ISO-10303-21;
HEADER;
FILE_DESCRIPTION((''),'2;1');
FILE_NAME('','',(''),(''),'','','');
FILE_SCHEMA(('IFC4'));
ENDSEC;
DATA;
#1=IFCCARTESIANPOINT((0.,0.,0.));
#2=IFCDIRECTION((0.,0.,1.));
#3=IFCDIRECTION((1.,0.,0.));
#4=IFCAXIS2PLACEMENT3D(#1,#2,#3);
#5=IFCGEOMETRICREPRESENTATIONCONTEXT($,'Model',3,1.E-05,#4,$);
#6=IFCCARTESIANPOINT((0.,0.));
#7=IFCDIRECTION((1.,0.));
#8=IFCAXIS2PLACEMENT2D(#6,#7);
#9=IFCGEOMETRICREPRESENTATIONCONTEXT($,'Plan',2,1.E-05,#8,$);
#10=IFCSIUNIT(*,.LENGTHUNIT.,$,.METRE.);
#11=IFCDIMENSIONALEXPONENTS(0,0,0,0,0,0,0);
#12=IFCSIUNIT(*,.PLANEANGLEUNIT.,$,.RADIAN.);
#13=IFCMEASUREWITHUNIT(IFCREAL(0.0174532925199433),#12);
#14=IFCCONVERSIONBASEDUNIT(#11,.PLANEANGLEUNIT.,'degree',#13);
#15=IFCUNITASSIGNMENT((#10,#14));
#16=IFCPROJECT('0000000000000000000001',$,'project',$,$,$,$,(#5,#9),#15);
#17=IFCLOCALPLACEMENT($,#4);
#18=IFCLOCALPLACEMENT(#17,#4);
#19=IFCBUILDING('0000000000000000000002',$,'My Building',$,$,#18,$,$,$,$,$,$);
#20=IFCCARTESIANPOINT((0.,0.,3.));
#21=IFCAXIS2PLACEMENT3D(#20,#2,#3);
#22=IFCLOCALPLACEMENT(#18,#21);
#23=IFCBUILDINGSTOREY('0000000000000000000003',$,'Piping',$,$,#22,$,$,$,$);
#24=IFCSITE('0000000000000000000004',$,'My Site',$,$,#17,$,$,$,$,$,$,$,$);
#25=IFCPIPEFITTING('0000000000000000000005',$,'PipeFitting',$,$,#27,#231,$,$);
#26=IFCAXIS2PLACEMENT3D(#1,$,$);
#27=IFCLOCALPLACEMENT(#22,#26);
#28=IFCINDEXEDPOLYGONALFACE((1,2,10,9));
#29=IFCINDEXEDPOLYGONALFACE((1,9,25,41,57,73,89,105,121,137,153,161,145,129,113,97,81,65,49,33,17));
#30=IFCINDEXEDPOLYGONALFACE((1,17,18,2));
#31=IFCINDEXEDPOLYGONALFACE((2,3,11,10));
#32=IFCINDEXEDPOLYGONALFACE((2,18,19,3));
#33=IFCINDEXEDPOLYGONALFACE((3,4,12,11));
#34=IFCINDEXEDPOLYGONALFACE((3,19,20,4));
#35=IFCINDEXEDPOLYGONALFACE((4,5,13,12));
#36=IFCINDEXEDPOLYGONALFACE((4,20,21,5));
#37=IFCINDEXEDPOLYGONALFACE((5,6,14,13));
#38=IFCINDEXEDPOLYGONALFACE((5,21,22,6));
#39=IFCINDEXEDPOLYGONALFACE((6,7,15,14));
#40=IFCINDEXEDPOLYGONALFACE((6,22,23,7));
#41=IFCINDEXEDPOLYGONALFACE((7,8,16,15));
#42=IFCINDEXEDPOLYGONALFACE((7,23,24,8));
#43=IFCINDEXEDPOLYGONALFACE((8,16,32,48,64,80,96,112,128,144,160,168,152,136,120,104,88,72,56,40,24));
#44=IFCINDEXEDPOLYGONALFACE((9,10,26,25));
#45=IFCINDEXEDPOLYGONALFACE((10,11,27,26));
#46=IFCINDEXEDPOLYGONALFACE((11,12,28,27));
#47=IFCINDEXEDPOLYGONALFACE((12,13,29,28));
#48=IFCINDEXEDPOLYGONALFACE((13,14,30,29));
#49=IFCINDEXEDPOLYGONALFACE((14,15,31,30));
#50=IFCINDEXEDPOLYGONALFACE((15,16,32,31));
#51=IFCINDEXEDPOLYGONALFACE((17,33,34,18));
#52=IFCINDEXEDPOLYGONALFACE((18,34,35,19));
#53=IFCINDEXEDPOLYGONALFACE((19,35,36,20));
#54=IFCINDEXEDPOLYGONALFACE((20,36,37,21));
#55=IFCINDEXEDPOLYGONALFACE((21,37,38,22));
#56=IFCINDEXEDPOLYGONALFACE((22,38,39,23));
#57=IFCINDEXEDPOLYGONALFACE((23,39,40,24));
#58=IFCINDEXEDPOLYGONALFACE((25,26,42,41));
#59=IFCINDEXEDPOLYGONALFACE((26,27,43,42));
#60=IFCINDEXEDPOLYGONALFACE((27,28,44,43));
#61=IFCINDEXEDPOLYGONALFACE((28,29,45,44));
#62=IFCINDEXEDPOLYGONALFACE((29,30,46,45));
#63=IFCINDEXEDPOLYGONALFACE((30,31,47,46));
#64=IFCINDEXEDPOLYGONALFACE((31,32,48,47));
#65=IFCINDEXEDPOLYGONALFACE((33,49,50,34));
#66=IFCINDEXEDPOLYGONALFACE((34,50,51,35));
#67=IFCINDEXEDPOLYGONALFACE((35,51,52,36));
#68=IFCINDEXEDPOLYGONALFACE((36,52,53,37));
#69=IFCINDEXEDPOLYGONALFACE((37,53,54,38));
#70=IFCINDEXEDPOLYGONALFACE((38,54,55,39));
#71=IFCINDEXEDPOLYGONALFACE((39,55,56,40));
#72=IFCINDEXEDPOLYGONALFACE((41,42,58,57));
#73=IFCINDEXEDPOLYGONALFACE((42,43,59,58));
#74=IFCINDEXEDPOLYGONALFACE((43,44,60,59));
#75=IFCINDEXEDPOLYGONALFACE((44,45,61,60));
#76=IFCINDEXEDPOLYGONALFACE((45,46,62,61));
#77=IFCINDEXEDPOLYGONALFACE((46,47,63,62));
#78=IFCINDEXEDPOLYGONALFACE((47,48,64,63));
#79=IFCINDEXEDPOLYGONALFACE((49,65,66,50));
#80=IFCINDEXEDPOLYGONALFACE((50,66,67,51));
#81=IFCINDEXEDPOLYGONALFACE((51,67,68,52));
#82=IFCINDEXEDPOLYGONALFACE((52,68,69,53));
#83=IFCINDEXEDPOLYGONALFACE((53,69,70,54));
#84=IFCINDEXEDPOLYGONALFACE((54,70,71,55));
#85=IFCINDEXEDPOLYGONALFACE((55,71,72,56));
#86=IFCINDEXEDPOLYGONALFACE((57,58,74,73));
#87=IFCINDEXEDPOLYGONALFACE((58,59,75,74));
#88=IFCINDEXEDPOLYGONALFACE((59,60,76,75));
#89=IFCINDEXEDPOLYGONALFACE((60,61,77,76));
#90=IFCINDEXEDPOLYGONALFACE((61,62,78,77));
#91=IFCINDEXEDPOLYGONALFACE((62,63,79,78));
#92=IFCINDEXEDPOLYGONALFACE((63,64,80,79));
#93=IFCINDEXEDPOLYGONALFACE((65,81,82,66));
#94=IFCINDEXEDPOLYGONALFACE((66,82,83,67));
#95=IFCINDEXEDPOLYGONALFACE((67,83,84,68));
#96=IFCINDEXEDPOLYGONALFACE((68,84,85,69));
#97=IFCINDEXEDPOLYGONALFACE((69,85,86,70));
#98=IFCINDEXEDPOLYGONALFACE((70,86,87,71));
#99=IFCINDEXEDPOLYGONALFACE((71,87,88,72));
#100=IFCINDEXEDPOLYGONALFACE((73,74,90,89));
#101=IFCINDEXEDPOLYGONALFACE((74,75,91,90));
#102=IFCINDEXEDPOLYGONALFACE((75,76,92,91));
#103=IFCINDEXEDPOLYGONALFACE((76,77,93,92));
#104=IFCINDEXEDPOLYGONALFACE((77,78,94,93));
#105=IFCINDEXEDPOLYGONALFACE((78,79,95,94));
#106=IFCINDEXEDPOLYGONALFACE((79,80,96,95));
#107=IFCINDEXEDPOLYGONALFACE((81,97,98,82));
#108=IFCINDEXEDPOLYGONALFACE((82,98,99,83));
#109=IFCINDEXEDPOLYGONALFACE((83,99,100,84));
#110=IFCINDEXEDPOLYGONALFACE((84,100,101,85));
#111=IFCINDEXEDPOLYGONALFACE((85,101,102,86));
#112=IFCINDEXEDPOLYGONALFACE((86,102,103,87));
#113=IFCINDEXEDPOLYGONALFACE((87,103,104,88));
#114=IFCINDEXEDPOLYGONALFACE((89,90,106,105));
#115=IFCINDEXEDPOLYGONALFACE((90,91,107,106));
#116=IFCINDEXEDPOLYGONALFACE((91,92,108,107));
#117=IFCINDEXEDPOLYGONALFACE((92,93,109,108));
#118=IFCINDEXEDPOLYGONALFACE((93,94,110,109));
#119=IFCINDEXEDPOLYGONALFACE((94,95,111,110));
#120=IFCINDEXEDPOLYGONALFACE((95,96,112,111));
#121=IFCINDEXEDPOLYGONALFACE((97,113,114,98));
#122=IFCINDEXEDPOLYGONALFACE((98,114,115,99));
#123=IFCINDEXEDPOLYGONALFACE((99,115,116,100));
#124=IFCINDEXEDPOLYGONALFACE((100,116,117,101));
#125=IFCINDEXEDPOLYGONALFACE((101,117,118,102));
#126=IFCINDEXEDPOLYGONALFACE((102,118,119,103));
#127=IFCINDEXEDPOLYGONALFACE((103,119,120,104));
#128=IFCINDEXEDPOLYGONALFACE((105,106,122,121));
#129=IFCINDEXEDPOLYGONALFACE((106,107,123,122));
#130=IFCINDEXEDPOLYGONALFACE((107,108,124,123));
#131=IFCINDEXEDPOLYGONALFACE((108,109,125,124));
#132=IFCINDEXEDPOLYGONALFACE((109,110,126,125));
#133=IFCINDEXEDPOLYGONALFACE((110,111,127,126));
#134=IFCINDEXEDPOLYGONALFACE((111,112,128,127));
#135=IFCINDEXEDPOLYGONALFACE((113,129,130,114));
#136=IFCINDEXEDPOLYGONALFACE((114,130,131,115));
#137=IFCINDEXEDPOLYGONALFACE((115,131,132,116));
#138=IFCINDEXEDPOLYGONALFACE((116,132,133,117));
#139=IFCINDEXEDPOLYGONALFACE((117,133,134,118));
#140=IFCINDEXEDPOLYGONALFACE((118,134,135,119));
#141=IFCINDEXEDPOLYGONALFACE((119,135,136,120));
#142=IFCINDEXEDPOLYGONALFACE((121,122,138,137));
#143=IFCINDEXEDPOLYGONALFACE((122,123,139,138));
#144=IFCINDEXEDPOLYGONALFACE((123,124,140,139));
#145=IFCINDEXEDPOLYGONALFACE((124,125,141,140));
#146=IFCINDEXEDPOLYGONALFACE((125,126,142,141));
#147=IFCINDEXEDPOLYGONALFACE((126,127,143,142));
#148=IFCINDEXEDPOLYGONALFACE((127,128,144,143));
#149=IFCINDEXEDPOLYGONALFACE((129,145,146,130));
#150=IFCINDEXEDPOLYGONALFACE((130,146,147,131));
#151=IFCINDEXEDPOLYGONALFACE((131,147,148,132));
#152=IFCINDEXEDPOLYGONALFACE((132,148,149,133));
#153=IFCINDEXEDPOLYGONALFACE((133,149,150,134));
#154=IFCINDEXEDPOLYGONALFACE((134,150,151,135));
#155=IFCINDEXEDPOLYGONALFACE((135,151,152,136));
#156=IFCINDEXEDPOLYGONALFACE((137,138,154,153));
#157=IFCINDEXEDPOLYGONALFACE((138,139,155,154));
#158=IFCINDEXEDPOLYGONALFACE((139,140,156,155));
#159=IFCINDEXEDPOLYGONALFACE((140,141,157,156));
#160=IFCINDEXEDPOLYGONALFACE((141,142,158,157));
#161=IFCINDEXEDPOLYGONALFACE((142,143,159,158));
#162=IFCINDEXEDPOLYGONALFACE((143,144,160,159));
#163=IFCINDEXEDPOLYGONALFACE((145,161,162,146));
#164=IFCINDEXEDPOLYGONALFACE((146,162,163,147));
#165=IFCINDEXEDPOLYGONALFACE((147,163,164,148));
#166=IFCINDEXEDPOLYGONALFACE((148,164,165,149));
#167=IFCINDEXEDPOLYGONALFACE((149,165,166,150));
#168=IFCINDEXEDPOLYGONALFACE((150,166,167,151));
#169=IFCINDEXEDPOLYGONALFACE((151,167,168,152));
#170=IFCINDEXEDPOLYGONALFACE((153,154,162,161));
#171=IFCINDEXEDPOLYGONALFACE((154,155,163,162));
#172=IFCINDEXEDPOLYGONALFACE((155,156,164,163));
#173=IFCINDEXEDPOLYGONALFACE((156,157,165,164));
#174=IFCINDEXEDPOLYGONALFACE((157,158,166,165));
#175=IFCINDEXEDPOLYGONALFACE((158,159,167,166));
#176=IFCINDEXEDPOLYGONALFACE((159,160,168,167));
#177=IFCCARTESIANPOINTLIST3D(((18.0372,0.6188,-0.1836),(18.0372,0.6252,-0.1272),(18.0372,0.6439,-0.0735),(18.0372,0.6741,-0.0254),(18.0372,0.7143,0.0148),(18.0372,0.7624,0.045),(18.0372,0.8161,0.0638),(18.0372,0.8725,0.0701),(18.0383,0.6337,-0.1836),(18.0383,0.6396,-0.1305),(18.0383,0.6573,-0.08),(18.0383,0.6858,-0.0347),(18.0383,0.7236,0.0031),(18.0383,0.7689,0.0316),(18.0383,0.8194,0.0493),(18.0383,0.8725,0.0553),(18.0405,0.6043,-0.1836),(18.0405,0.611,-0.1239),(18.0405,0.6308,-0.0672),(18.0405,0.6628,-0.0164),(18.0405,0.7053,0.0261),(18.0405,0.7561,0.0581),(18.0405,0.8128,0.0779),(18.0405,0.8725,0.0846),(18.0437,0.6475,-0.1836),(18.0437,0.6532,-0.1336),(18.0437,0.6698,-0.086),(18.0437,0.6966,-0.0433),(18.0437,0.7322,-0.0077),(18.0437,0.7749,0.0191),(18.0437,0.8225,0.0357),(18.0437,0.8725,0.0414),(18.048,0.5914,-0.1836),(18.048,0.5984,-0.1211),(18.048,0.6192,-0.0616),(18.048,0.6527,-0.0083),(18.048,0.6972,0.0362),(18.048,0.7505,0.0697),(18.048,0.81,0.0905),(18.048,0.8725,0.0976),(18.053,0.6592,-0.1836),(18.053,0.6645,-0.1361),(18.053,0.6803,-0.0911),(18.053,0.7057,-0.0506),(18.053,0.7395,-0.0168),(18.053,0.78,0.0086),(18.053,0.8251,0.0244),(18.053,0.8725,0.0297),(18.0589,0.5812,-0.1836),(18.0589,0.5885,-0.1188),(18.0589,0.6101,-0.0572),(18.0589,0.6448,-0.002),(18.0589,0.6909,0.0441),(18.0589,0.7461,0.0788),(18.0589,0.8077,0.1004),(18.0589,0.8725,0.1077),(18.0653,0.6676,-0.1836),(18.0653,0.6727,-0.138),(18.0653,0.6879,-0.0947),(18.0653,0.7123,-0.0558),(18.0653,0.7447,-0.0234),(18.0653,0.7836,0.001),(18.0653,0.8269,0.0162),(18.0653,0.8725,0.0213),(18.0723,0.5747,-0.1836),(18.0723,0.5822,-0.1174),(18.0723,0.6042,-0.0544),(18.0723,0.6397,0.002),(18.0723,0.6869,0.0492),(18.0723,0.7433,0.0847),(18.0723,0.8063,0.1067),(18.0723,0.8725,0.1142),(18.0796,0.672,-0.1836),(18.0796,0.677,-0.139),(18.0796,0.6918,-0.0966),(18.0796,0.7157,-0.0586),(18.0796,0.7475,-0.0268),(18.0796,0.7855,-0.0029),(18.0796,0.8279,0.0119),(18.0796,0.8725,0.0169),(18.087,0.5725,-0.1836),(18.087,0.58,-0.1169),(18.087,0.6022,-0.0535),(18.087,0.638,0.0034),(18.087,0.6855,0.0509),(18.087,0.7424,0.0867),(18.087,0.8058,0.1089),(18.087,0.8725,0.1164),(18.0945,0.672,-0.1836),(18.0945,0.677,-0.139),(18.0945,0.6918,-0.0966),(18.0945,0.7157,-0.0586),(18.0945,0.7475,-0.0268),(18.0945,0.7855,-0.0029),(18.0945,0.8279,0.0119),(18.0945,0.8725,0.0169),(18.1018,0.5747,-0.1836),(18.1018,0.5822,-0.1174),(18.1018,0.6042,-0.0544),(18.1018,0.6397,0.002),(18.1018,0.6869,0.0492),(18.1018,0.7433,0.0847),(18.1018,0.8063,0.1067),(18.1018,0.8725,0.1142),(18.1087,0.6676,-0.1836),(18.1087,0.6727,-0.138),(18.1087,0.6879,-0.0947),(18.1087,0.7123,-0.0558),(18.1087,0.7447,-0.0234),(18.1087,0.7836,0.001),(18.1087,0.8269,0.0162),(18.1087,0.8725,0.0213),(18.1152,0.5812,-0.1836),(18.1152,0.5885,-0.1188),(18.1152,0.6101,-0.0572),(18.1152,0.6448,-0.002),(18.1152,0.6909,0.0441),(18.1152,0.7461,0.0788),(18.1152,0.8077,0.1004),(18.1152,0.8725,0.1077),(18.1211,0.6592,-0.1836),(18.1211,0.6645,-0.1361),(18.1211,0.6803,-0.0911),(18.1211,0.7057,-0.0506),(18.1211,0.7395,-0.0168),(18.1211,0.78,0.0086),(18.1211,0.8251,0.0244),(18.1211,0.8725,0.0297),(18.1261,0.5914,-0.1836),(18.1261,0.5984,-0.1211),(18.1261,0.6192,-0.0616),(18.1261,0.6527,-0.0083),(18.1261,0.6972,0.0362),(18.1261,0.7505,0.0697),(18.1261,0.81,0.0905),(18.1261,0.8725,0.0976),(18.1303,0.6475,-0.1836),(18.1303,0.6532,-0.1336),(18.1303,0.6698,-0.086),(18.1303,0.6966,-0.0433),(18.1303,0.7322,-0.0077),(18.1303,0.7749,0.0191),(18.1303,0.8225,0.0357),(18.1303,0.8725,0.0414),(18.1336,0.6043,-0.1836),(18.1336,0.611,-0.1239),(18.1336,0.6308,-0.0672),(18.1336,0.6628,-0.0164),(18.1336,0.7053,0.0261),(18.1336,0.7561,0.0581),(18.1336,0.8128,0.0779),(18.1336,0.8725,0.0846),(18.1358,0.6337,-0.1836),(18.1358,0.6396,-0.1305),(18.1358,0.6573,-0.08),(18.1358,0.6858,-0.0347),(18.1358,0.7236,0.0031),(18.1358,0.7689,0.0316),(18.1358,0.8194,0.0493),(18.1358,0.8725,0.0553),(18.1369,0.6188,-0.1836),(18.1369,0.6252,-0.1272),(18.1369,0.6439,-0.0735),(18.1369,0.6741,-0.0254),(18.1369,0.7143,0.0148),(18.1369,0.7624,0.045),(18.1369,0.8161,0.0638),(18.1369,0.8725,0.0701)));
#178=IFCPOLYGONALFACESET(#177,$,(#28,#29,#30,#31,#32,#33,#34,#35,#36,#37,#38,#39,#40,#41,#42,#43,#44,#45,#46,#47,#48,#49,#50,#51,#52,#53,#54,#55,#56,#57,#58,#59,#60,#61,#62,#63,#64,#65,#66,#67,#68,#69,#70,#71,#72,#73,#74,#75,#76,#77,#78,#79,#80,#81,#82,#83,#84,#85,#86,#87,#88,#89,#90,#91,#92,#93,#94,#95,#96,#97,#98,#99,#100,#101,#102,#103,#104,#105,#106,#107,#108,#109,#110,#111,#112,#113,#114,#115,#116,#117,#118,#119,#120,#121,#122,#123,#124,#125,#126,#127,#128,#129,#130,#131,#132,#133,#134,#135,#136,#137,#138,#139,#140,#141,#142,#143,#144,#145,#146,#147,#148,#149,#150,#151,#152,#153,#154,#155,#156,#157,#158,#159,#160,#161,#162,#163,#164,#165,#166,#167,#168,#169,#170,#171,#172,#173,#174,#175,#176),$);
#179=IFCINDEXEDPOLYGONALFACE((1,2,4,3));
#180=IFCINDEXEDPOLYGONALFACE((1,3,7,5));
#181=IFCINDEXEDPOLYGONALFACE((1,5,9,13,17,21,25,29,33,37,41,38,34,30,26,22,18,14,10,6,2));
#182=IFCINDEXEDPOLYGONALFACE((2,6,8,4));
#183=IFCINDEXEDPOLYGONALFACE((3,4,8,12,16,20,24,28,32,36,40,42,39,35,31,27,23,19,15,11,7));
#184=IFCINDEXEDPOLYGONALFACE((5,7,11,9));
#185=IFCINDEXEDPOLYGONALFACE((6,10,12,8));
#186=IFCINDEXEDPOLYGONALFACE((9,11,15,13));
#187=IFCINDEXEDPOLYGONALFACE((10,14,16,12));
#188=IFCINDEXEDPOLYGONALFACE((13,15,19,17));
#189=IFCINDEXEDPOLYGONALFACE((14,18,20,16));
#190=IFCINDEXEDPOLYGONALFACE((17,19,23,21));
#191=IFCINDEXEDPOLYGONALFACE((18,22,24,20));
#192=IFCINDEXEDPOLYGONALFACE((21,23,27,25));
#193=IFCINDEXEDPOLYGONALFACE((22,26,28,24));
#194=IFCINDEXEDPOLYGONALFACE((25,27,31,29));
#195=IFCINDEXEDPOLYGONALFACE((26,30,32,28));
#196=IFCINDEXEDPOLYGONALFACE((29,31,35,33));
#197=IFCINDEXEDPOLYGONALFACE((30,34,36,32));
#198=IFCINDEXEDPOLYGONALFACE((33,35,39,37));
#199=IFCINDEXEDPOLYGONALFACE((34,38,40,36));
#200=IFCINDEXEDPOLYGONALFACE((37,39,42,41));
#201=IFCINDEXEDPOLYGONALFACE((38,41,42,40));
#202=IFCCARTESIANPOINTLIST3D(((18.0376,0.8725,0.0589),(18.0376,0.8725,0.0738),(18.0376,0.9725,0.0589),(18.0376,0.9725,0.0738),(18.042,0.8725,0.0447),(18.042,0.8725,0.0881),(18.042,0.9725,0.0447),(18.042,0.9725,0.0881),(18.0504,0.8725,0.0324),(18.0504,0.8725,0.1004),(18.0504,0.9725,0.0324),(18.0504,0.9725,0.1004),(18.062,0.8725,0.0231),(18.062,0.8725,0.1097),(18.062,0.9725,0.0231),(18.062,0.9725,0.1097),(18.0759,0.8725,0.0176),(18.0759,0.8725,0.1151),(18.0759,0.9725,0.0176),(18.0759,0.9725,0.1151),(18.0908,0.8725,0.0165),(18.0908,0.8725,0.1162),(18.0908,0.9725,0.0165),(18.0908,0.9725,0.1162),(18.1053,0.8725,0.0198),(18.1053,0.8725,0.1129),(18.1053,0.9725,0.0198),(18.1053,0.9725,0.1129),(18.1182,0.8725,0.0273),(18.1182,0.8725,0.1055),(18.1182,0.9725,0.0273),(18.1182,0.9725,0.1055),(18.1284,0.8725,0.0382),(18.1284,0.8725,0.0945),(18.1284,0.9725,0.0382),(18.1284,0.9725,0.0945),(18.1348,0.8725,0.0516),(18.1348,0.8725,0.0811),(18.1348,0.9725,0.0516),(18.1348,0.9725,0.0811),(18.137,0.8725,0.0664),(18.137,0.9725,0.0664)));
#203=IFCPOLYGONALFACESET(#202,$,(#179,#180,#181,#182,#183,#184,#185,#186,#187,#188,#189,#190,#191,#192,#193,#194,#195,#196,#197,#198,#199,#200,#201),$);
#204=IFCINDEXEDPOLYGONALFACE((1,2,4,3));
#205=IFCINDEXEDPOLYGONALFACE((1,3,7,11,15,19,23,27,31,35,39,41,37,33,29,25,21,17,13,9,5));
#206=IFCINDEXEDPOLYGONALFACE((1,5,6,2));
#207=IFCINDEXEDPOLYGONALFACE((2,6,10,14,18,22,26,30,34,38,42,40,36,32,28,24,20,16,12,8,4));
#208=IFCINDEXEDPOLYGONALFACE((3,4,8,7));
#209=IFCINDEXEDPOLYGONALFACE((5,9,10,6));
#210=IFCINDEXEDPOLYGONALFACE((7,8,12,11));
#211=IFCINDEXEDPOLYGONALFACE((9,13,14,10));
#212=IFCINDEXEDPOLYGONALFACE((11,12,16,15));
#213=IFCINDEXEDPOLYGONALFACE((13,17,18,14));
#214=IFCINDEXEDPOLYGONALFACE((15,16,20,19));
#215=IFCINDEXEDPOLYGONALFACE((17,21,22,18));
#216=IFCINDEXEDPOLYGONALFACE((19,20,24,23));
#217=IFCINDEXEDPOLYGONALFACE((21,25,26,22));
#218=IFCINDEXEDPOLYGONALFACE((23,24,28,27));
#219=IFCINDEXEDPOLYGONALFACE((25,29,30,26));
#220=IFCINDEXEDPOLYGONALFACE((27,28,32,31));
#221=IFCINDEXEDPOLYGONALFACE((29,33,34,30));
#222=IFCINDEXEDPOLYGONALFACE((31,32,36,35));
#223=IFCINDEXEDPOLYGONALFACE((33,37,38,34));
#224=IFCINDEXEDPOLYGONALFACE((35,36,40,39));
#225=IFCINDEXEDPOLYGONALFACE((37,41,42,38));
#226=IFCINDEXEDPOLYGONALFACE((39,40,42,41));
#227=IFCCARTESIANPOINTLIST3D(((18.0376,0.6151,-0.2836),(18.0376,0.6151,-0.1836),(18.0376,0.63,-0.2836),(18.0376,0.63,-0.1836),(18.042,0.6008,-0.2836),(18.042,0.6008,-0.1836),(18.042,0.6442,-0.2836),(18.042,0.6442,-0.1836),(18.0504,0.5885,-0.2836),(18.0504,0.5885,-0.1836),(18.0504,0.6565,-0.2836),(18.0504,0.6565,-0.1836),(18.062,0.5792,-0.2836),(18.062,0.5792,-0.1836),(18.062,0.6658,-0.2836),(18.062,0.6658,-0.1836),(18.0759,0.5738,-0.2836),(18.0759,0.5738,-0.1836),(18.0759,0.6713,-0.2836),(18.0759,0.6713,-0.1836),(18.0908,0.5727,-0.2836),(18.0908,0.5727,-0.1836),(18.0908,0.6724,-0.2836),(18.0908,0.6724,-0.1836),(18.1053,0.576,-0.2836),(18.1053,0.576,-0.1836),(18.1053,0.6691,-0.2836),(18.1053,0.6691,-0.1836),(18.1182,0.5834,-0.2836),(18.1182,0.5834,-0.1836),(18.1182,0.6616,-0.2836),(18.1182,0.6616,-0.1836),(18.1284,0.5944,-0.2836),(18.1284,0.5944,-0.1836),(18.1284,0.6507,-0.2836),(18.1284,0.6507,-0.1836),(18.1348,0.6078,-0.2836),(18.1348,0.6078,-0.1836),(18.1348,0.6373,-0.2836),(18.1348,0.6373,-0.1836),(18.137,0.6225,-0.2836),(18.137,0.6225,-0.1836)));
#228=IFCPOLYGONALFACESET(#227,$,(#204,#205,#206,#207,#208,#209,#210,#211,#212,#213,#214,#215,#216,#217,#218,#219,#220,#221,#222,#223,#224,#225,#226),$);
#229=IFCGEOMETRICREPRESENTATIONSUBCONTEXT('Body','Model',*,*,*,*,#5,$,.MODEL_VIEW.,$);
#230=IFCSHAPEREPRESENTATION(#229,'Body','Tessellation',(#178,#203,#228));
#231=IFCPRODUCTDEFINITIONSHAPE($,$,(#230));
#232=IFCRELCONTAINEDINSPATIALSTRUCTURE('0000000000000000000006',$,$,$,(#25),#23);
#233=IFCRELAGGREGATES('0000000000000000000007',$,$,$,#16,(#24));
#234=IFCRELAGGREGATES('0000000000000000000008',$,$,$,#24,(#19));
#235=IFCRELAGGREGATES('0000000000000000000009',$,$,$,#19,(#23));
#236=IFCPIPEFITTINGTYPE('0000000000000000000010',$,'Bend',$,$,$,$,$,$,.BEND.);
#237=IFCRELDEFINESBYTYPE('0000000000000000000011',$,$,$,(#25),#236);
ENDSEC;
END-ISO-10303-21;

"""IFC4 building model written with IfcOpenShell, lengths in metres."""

from ifc_helpers import new_model, entity, si_unit, converted_unit, frame, origin_with_axes, origin_2d_with_axis, place, context, subcontext, project, spatial, circle, extrude, source, transform, mapped, type_object, type_shapes, element, save


model = new_model("IFC4")

# Units and contexts
model_context = context("Model", 3, precision=1e-05, world=origin_with_axes())
plan_context = context("Plan", 2, precision=1e-05, world=origin_2d_with_axis())
body_context = subcontext(model_context, "Body", "Model", "MODEL_VIEW")
ifc_project = project(units=[si_unit("LENGTHUNIT", "METRE"), converted_unit("PLANEANGLEUNIT", "degree", entity("IfcReal", 0.0174532925199433), si_unit("PLANEANGLEUNIT", "RADIAN"), dimensions=[0, 0, 0, 0, 0, 0, 0])], contexts=[model_context, plan_context])

# Site, building, storey
site_placement = place(None, origin_with_axes())
site = spatial("IfcSite", under=ifc_project, at=site_placement, Name="My Site")
building_placement = place(site_placement, origin_with_axes())
building = spatial("IfcBuilding", under=site, at=building_placement, Name="My Building")
storey_placement = place(building_placement, frame((0.0, 0.0, 3.0), z_axis=(0.0, 0.0, 1.0), x_axis=(1.0, 0.0, 0.0)))
storey = spatial("IfcBuildingStorey", under=building, at=storey_placement, Name="Piping")

# Pipe fitting
pipe_fitting_type_1 = type_object("IfcPipeFittingType", Name="Bend", PredefinedType="BEND")
shared_shape = source(origin_with_axes(), body_context, "Body", "SolidModel", [
    entity("IfcSweptDiskSolid", entity("IfcIndexedPolyCurve", entity("IfcCartesianPointList3D", [[0.0, 0.0, 0.1], [0.0, -0.0732, 0.2768], [0.0, -0.25, 0.35]]), [entity("IfcArcIndex", [1, 2, 3])]), 0.05),
    extrude(circle(Radius=0.05), origin_with_axes(), (0.0, 0.0, 1.0), 0.1),
    extrude(circle(Radius=0.05), frame((0.0, -0.25, 0.35), z_axis=(0.0, -1.0, -0.000002), x_axis=(1.0, 0.0, 0.0)), (0.0, 0.0, 1.0), 0.1),
])
type_shapes(pipe_fitting_type_1, [shared_shape])
for number, where, z_axis, x_axis, name in (
    (1, (18.087, 0.9725, 0.0664), (0.0, -1.0, 0.000002), (1.0, 0.0, 0.0), "PipeFitting"),
):
    element("IfcPipeFitting", number, at=place(storey_placement, frame(where, z_axis=z_axis, x_axis=x_axis)), inside=storey, type_object=pipe_fitting_type_1, Name=name, context=body_context, shape_type="MappedRepresentation", body=[
        mapped(shared_shape, transform((0.0, 0.0, 0.0), x_axis=(1.0, 0.0, 0.0), y_axis=(0.0, 1.0, 0.0), z_axis=(0.0, 0.0, 1.0), scale=1.0)),
    ])

save(model, "model.ifc")
